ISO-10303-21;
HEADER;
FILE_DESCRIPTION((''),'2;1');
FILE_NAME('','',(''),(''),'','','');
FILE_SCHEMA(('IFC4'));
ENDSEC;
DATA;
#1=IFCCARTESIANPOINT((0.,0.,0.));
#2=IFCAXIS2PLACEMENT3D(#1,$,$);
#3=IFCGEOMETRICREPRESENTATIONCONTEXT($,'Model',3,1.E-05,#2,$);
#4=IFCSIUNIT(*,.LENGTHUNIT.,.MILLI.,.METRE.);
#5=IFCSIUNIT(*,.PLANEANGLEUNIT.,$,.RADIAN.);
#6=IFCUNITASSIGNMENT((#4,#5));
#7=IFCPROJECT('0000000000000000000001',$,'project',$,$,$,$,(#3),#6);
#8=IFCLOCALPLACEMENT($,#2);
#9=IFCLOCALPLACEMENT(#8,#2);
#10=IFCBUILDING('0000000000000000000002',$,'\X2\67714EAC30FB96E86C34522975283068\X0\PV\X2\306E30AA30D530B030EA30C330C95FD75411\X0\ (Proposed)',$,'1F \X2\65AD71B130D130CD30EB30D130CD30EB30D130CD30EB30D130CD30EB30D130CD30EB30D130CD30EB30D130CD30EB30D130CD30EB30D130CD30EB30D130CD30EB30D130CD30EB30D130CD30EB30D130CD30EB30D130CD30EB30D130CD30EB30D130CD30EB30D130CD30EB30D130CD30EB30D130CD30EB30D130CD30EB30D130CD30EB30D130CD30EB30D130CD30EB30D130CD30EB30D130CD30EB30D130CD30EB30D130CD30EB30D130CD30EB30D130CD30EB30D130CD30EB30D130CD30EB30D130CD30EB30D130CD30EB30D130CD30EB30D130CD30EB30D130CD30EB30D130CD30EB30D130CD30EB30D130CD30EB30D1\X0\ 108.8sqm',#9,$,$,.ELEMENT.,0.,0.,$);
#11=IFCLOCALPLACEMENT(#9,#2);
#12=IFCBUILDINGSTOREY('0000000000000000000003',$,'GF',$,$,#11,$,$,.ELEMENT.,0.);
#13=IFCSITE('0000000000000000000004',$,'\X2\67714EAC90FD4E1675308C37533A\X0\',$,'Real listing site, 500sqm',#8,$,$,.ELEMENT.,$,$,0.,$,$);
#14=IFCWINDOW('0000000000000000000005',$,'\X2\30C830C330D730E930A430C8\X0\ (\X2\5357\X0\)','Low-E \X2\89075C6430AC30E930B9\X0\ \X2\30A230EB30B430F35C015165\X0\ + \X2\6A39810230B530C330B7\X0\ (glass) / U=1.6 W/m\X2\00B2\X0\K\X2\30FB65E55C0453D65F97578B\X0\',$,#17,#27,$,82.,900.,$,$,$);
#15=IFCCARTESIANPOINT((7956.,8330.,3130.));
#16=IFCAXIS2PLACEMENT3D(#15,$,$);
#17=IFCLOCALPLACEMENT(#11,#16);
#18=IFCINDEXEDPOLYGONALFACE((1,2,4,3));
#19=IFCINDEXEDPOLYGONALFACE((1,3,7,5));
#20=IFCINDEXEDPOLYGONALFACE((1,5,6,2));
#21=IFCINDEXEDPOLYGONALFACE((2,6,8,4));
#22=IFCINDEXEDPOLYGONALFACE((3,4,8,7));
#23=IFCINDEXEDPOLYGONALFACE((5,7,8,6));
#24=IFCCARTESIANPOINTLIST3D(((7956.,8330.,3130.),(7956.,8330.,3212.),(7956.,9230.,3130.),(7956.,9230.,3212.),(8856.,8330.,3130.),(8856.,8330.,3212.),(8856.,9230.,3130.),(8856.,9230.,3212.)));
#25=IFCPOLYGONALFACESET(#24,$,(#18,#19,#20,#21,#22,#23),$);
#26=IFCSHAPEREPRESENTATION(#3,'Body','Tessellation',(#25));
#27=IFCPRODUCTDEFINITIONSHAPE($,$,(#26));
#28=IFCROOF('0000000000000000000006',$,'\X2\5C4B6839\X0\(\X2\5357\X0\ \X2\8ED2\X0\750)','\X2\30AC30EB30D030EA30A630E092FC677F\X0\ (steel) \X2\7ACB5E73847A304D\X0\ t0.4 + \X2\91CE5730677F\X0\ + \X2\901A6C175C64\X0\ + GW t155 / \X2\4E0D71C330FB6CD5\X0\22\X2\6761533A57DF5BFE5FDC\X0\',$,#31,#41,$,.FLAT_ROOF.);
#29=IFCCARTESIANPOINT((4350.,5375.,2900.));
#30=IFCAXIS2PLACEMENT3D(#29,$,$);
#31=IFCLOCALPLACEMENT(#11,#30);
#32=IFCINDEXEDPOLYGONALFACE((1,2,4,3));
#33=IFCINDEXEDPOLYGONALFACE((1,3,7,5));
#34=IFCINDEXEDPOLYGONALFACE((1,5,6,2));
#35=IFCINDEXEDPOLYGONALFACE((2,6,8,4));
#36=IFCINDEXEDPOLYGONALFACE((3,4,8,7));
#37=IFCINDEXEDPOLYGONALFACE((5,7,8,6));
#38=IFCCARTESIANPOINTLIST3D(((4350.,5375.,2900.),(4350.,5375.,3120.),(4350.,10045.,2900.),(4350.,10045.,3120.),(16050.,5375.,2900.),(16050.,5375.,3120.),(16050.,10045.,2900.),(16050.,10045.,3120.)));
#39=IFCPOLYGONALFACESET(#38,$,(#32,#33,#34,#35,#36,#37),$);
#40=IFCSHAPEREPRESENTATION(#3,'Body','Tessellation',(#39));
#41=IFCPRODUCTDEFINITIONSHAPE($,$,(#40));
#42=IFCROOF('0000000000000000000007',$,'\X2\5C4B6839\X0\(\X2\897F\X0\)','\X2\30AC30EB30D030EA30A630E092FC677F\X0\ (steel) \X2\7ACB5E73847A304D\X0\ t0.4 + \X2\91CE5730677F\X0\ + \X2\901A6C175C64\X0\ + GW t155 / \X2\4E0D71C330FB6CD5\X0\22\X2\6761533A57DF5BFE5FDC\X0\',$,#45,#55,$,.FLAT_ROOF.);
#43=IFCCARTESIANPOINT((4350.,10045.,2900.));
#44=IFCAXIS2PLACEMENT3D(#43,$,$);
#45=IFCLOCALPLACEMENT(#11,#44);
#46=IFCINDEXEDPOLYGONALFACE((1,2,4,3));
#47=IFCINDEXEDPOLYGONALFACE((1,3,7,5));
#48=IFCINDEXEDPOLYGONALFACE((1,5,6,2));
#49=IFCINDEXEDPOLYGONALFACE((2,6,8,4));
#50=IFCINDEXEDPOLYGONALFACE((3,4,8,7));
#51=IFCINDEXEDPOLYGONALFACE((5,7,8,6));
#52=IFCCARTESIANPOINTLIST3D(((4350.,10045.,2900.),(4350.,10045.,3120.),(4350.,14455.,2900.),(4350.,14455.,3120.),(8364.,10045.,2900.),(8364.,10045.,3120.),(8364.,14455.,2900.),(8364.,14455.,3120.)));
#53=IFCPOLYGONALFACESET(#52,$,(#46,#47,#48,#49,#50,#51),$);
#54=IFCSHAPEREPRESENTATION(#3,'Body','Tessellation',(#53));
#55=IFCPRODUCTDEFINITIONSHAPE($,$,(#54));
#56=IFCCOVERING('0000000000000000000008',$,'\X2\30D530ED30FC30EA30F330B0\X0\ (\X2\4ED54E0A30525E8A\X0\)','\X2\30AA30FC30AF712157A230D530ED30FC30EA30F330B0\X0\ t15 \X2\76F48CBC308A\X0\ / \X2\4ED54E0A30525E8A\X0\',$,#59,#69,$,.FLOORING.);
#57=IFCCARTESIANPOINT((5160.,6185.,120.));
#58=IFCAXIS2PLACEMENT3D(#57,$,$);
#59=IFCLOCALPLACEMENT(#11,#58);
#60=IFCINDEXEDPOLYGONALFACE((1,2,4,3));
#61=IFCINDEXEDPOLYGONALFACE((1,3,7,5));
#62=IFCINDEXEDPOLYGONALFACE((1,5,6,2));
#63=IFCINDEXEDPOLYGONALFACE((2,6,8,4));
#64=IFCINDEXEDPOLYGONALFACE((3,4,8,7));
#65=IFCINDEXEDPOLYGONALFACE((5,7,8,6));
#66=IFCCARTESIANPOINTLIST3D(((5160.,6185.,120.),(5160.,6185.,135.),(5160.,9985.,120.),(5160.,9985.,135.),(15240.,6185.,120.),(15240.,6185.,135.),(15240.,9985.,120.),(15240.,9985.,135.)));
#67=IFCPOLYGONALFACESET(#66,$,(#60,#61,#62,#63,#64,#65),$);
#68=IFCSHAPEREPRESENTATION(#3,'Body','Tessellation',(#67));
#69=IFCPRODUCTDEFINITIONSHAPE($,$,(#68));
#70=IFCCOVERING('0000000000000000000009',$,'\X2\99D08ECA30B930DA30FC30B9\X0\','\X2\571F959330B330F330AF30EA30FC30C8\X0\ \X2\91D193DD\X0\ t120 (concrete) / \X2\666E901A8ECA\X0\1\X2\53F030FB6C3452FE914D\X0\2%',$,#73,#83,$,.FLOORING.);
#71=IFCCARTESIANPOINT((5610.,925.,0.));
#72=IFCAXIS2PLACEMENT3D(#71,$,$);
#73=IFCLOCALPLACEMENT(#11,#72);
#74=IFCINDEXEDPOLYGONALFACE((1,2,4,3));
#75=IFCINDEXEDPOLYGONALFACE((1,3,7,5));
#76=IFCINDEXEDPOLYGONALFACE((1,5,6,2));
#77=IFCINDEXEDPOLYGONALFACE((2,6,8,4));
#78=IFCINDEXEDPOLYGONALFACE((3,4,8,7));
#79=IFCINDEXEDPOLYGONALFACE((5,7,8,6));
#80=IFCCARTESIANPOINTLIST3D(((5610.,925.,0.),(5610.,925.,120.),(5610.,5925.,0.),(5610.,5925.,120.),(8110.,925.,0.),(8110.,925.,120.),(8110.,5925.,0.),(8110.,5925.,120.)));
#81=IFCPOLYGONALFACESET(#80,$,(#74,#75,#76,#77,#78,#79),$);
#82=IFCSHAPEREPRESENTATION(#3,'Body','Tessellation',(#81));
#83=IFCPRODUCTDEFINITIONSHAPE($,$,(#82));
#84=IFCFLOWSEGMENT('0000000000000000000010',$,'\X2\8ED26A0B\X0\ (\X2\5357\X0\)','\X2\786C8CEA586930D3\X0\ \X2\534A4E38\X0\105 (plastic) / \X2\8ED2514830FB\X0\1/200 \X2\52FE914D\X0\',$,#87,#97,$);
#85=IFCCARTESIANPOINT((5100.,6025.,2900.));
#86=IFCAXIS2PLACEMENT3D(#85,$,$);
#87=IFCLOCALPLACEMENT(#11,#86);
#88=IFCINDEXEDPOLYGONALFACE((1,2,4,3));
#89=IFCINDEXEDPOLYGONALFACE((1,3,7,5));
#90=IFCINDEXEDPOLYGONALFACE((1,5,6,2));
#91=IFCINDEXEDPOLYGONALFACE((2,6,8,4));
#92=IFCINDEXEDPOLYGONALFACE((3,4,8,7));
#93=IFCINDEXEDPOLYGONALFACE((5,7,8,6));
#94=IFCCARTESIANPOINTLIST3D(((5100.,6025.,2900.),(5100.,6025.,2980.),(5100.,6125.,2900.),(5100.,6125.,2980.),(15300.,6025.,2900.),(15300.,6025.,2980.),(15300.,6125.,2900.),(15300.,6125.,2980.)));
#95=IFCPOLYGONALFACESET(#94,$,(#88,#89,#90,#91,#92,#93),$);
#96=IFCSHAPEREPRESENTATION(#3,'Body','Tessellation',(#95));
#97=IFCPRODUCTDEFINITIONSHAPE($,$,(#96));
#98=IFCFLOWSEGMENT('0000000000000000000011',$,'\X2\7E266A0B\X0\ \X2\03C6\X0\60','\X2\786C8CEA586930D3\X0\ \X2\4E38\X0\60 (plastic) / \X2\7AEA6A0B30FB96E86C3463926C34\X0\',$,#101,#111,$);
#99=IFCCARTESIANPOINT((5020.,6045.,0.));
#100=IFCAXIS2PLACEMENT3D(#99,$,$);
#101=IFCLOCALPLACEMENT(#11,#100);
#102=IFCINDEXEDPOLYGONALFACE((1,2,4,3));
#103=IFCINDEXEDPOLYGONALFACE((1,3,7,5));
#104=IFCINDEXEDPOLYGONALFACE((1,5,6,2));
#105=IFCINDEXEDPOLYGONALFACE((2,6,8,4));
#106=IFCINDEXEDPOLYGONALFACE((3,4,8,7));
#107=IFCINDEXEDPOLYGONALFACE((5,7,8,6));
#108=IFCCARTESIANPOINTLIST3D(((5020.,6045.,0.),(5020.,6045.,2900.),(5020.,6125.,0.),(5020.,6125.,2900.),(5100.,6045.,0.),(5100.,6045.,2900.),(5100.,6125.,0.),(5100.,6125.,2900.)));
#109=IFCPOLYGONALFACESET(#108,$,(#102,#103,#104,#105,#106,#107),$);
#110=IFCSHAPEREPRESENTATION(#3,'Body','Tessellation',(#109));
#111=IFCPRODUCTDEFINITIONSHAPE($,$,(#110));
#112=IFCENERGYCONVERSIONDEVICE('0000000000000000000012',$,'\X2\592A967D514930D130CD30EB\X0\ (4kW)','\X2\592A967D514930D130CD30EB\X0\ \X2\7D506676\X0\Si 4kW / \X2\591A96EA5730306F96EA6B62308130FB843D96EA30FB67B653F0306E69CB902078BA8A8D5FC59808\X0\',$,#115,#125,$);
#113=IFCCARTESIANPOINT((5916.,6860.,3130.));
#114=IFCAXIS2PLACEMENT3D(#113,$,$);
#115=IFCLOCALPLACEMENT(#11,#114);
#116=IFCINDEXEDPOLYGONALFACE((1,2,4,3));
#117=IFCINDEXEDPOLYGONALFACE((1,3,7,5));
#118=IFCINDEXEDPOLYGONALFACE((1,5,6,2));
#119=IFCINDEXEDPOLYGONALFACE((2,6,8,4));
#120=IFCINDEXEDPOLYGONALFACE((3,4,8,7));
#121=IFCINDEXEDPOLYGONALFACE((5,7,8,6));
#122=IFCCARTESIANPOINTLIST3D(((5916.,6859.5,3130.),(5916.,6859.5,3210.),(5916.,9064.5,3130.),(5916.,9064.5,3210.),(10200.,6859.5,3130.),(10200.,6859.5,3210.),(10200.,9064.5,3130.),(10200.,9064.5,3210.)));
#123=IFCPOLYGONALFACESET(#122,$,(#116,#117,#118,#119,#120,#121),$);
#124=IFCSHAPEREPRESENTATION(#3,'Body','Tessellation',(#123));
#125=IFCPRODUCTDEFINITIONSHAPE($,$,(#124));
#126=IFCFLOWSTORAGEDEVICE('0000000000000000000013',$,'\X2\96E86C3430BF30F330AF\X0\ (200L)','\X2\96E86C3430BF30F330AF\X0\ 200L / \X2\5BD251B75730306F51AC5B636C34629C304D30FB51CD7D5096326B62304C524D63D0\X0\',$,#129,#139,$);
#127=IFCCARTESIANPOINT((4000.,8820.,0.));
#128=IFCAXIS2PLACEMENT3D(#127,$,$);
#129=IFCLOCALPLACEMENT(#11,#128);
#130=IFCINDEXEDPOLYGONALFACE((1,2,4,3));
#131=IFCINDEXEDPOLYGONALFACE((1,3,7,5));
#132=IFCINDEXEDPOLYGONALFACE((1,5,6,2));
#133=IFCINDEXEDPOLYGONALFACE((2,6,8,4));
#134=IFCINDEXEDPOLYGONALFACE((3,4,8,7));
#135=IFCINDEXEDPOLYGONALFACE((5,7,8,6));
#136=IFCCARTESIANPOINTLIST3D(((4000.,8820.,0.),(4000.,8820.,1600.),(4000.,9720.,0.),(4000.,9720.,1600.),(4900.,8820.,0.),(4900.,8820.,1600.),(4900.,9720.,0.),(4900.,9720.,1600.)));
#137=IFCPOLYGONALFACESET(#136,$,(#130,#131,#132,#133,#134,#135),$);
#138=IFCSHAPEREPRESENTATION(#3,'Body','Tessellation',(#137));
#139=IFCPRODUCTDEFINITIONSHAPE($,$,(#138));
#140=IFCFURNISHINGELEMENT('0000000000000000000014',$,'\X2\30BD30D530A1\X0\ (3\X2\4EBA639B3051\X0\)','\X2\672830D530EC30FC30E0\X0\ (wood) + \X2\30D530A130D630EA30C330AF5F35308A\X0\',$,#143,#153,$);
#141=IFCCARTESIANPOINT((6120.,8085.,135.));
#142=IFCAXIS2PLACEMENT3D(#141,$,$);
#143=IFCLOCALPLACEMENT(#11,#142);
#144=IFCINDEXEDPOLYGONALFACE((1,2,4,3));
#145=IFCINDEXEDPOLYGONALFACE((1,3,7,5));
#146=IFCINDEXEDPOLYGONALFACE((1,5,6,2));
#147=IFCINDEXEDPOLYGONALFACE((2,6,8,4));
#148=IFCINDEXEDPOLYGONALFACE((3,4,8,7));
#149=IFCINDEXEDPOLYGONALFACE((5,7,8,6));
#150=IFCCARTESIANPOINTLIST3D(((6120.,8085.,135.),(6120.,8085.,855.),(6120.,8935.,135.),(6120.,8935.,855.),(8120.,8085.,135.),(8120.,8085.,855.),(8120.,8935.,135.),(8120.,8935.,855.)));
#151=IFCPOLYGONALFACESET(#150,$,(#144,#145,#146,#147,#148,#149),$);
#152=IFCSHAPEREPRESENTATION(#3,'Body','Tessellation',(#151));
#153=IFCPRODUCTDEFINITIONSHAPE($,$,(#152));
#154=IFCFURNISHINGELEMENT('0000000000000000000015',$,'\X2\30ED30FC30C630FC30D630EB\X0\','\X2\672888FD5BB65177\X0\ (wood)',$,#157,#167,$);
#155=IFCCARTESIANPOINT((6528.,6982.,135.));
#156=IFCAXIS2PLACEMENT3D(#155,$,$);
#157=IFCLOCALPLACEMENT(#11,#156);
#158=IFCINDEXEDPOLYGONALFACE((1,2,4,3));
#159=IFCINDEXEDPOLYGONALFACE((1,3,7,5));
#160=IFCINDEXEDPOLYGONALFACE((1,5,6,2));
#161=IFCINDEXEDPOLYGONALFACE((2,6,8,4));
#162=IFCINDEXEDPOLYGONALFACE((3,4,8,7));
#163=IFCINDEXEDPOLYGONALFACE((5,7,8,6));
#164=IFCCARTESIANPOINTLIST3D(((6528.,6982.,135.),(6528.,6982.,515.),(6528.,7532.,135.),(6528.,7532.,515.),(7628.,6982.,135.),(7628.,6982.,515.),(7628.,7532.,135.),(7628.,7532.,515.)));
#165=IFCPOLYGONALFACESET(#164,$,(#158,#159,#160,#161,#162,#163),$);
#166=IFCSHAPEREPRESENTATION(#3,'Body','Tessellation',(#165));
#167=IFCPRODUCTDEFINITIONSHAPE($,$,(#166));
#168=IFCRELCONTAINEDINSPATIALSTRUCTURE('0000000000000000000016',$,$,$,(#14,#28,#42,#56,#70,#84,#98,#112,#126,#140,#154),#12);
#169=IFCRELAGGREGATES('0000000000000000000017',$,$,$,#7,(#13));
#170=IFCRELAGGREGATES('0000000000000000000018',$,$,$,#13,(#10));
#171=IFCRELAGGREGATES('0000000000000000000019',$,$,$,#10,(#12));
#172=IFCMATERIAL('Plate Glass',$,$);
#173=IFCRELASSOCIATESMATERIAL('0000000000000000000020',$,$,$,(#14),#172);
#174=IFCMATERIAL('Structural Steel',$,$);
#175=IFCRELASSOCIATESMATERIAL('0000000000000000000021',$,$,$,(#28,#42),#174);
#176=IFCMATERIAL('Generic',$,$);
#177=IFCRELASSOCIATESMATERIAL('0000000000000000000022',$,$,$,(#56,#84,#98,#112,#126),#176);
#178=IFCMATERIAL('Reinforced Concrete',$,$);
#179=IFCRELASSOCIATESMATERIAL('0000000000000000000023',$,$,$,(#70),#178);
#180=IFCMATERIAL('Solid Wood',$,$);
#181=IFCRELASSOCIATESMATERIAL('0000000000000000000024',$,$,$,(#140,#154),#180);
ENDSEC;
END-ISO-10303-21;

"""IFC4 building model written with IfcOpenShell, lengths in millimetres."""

from ifc_helpers import new_model, si_unit, frame, frame_2d, origin, place, context, project, spatial, rectangle, extrude, material, element, save


model = new_model("IFC4")

# Units and contexts
model_context = context("Model", 3, precision=1e-05, world=origin())
ifc_project = project(units=[si_unit("LENGTHUNIT", "METRE", prefix="MILLI"), si_unit("PLANEANGLEUNIT", "RADIAN")], contexts=[model_context])

# Site, building, storey
site_placement = place(None, origin())
site = spatial("IfcSite", under=ifc_project, at=site_placement, Name="東京都世田谷区", ObjectType="Real listing site, 500sqm", CompositionType="ELEMENT", RefElevation=0.0)
building_placement = place(site_placement, origin())
building = spatial("IfcBuilding", under=site, at=building_placement, Name="東京・雨水利用とPVのオフグリッド志向 (Proposed)", ObjectType="1F 断熱パネルパネルパネルパネルパネルパネルパネルパネルパネルパネルパネルパネルパネルパネルパネルパネルパネルパネルパネルパネルパネルパネルパネルパネルパネルパネルパネルパネルパネルパネルパネルパネルパネルパネルパネルパネルパネルパネルパネルパ 108.8sqm", CompositionType="ELEMENT", ElevationOfRefHeight=0.0, ElevationOfTerrain=0.0)
storey_placement = place(building_placement, origin())
storey = spatial("IfcBuildingStorey", under=building, at=storey_placement, Name="GF", CompositionType="ELEMENT", Elevation=0.0)

# Shared definitions
ifc_material_1 = material(Name="Solid Wood")

# Shared definitions
ifc_material_2 = material(Name="Reinforced Concrete")

# Shared definitions
ifc_material_3 = material(Name="Plate Glass")

# Window
window_1_placement = place(storey_placement, frame((7956.0, 8330.0, 3130.0)))
element("IfcWindow", 1, at=window_1_placement, inside=storey, material=ifc_material_3, Name="トップライト (南)", Description="Low-E 複層ガラス アルゴン封入 + 樹脂サッシ (glass) / U=1.6 W/m²K・日射取得型", OverallHeight=82.0, OverallWidth=900.0, context=model_context, shape_type="SweptSolid", body=[
    extrude(rectangle(XDim=900.0, YDim=900.0, at=frame_2d((450.0, 450.0))), frame((7956.0, 8330.0, 3130.0)), (0.0, 0.0, 1.0), 82.0),
])

# Roofs
ifc_material_4 = material(Name="Structural Steel")
roof_1_placement = place(storey_placement, frame((4350.0, 5375.0, 2900.0)))
element("IfcRoof", 2, at=roof_1_placement, inside=storey, material=ifc_material_4, Name="屋根(南 軒750)", Description="ガルバリウム鋼板 (steel) 立平葺き t0.4 + 野地板 + 通気層 + GW t155 / 不燃・法22条区域対応", PredefinedType="FLAT_ROOF", context=model_context, shape_type="SweptSolid", body=[
    extrude(rectangle(XDim=11700.0, YDim=4670.0, at=frame_2d((5850.0, 2335.0))), frame((4350.0, 5375.0, 2900.0)), (0.0, 0.0, 1.0), 220.0),
])
roof_2_placement = place(storey_placement, frame((4350.0, 10045.0, 2900.0)))
element("IfcRoof", 3, at=roof_2_placement, inside=storey, material=ifc_material_4, Name="屋根(西)", Description="ガルバリウム鋼板 (steel) 立平葺き t0.4 + 野地板 + 通気層 + GW t155 / 不燃・法22条区域対応", PredefinedType="FLAT_ROOF", context=model_context, shape_type="SweptSolid", body=[
    extrude(rectangle(XDim=4014.0, YDim=4410.0, at=frame_2d((2007.0, 2205.0))), frame((4350.0, 10045.0, 2900.0)), (0.0, 0.0, 1.0), 220.0),
])

# Coverings
ifc_material_5 = material(Name="Generic")
covering_1_placement = place(storey_placement, frame((5160.0, 6185.0, 120.0)))
element("IfcCovering", 4, at=covering_1_placement, inside=storey, material=ifc_material_5, Name="フローリング (仕上げ床)", Description="オーク無垢フローリング t15 直貼り / 仕上げ床", PredefinedType="FLOORING", context=model_context, shape_type="SweptSolid", body=[
    extrude(rectangle(XDim=10080.0, YDim=3800.0, at=frame_2d((5040.0, 1900.0))), frame((5160.0, 6185.0, 120.0)), (0.0, 0.0, 1.0), 15.0),
])
covering_2_placement = place(storey_placement, frame((5610.0, 925.0, 0.0)))
element("IfcCovering", 5, at=covering_2_placement, inside=storey, material=ifc_material_2, Name="駐車スペース", Description="土間コンクリート 金鏝 t120 (concrete) / 普通車1台・水勾配2%", PredefinedType="FLOORING", context=model_context, shape_type="SweptSolid", body=[
    extrude(rectangle(XDim=2500.0, YDim=5000.0, at=frame_2d((1250.0, 2500.0))), frame((5610.0, 925.0, 0.0)), (0.0, 0.0, 1.0), 120.0),
])

# Flow segments
flow_segment_1_placement = place(storey_placement, frame((5100.0, 6025.0, 2900.0)))
element("IfcFlowSegment", 6, at=flow_segment_1_placement, inside=storey, material=ifc_material_5, Name="軒樋 (南)", Description="硬質塩ビ 半丸105 (plastic) / 軒先・1/200 勾配", context=model_context, shape_type="SweptSolid", body=[
    extrude(rectangle(XDim=10200.0, YDim=100.0, at=frame_2d((5100.0, 50.0))), frame((5100.0, 6025.0, 2900.0)), (0.0, 0.0, 1.0), 80.0),
])
flow_segment_2_placement = place(storey_placement, frame((5020.0, 6045.0, 0.0)))
element("IfcFlowSegment", 7, at=flow_segment_2_placement, inside=storey, material=ifc_material_5, Name="縦樋 φ60", Description="硬質塩ビ 丸60 (plastic) / 竪樋・雨水排水", context=model_context, shape_type="SweptSolid", body=[
    extrude(rectangle(XDim=80.0, YDim=80.0, at=frame_2d((40.0, 40.0))), frame((5020.0, 6045.0, 0.0)), (0.0, 0.0, 1.0), 2900.0),
])

# Energy conversion device
energy_conversion_device_placement = place(storey_placement, frame((5916.0, 6860.0, 3130.0)))
element("IfcEnergyConversionDevice", 8, at=energy_conversion_device_placement, inside=storey, material=ifc_material_5, Name="太陽光パネル (4kW)", Description="太陽光パネル 結晶Si 4kW / 多雪地は雪止め・落雪・架台の構造確認必須", context=model_context, shape_type="SweptSolid", body=[
    extrude(rectangle(XDim=4284.0, YDim=2205.0, at=frame_2d((2142.0, 1102.0))), frame((5916.0, 6860.0, 3130.0)), (0.0, 0.0, 1.0), 80.0),
])

# Flow storage device
flow_storage_device_placement = place(storey_placement, frame((4000.0, 8820.0, 0.0)))
element("IfcFlowStorageDevice", 9, at=flow_storage_device_placement, inside=storey, material=ifc_material_5, Name="雨水タンク (200L)", Description="雨水タンク 200L / 寒冷地は冬季水抜き・凍結防止が前提", context=model_context, shape_type="SweptSolid", body=[
    extrude(rectangle(XDim=900.0, YDim=900.0, at=frame_2d((450.0, 450.0))), frame((4000.0, 8820.0, 0.0)), (0.0, 0.0, 1.0), 1600.0),
])

# Furnishing elements
furnishing_1_placement = place(storey_placement, frame((6120.0, 8085.0, 135.0)))
element("IfcFurnishingElement", 10, at=furnishing_1_placement, inside=storey, material=ifc_material_1, Name="ソファ (3人掛け)", Description="木フレーム (wood) + ファブリック張り", context=model_context, shape_type="SweptSolid", body=[
    extrude(rectangle(XDim=2000.0, YDim=850.0, at=frame_2d((1000.0, 425.0))), frame((6120.0, 8085.0, 135.0)), (0.0, 0.0, 1.0), 720.0),
])
furnishing_2_placement = place(storey_placement, frame((6528.0, 6982.0, 135.0)))
element("IfcFurnishingElement", 11, at=furnishing_2_placement, inside=storey, material=ifc_material_1, Name="ローテーブル", Description="木製家具 (wood)", context=model_context, shape_type="SweptSolid", body=[
    extrude(rectangle(XDim=1100.0, YDim=550.0, at=frame_2d((550.0, 275.0))), frame((6528.0, 6982.0, 135.0)), (0.0, 0.0, 1.0), 380.0),
])

save(model, "model.ifc")
